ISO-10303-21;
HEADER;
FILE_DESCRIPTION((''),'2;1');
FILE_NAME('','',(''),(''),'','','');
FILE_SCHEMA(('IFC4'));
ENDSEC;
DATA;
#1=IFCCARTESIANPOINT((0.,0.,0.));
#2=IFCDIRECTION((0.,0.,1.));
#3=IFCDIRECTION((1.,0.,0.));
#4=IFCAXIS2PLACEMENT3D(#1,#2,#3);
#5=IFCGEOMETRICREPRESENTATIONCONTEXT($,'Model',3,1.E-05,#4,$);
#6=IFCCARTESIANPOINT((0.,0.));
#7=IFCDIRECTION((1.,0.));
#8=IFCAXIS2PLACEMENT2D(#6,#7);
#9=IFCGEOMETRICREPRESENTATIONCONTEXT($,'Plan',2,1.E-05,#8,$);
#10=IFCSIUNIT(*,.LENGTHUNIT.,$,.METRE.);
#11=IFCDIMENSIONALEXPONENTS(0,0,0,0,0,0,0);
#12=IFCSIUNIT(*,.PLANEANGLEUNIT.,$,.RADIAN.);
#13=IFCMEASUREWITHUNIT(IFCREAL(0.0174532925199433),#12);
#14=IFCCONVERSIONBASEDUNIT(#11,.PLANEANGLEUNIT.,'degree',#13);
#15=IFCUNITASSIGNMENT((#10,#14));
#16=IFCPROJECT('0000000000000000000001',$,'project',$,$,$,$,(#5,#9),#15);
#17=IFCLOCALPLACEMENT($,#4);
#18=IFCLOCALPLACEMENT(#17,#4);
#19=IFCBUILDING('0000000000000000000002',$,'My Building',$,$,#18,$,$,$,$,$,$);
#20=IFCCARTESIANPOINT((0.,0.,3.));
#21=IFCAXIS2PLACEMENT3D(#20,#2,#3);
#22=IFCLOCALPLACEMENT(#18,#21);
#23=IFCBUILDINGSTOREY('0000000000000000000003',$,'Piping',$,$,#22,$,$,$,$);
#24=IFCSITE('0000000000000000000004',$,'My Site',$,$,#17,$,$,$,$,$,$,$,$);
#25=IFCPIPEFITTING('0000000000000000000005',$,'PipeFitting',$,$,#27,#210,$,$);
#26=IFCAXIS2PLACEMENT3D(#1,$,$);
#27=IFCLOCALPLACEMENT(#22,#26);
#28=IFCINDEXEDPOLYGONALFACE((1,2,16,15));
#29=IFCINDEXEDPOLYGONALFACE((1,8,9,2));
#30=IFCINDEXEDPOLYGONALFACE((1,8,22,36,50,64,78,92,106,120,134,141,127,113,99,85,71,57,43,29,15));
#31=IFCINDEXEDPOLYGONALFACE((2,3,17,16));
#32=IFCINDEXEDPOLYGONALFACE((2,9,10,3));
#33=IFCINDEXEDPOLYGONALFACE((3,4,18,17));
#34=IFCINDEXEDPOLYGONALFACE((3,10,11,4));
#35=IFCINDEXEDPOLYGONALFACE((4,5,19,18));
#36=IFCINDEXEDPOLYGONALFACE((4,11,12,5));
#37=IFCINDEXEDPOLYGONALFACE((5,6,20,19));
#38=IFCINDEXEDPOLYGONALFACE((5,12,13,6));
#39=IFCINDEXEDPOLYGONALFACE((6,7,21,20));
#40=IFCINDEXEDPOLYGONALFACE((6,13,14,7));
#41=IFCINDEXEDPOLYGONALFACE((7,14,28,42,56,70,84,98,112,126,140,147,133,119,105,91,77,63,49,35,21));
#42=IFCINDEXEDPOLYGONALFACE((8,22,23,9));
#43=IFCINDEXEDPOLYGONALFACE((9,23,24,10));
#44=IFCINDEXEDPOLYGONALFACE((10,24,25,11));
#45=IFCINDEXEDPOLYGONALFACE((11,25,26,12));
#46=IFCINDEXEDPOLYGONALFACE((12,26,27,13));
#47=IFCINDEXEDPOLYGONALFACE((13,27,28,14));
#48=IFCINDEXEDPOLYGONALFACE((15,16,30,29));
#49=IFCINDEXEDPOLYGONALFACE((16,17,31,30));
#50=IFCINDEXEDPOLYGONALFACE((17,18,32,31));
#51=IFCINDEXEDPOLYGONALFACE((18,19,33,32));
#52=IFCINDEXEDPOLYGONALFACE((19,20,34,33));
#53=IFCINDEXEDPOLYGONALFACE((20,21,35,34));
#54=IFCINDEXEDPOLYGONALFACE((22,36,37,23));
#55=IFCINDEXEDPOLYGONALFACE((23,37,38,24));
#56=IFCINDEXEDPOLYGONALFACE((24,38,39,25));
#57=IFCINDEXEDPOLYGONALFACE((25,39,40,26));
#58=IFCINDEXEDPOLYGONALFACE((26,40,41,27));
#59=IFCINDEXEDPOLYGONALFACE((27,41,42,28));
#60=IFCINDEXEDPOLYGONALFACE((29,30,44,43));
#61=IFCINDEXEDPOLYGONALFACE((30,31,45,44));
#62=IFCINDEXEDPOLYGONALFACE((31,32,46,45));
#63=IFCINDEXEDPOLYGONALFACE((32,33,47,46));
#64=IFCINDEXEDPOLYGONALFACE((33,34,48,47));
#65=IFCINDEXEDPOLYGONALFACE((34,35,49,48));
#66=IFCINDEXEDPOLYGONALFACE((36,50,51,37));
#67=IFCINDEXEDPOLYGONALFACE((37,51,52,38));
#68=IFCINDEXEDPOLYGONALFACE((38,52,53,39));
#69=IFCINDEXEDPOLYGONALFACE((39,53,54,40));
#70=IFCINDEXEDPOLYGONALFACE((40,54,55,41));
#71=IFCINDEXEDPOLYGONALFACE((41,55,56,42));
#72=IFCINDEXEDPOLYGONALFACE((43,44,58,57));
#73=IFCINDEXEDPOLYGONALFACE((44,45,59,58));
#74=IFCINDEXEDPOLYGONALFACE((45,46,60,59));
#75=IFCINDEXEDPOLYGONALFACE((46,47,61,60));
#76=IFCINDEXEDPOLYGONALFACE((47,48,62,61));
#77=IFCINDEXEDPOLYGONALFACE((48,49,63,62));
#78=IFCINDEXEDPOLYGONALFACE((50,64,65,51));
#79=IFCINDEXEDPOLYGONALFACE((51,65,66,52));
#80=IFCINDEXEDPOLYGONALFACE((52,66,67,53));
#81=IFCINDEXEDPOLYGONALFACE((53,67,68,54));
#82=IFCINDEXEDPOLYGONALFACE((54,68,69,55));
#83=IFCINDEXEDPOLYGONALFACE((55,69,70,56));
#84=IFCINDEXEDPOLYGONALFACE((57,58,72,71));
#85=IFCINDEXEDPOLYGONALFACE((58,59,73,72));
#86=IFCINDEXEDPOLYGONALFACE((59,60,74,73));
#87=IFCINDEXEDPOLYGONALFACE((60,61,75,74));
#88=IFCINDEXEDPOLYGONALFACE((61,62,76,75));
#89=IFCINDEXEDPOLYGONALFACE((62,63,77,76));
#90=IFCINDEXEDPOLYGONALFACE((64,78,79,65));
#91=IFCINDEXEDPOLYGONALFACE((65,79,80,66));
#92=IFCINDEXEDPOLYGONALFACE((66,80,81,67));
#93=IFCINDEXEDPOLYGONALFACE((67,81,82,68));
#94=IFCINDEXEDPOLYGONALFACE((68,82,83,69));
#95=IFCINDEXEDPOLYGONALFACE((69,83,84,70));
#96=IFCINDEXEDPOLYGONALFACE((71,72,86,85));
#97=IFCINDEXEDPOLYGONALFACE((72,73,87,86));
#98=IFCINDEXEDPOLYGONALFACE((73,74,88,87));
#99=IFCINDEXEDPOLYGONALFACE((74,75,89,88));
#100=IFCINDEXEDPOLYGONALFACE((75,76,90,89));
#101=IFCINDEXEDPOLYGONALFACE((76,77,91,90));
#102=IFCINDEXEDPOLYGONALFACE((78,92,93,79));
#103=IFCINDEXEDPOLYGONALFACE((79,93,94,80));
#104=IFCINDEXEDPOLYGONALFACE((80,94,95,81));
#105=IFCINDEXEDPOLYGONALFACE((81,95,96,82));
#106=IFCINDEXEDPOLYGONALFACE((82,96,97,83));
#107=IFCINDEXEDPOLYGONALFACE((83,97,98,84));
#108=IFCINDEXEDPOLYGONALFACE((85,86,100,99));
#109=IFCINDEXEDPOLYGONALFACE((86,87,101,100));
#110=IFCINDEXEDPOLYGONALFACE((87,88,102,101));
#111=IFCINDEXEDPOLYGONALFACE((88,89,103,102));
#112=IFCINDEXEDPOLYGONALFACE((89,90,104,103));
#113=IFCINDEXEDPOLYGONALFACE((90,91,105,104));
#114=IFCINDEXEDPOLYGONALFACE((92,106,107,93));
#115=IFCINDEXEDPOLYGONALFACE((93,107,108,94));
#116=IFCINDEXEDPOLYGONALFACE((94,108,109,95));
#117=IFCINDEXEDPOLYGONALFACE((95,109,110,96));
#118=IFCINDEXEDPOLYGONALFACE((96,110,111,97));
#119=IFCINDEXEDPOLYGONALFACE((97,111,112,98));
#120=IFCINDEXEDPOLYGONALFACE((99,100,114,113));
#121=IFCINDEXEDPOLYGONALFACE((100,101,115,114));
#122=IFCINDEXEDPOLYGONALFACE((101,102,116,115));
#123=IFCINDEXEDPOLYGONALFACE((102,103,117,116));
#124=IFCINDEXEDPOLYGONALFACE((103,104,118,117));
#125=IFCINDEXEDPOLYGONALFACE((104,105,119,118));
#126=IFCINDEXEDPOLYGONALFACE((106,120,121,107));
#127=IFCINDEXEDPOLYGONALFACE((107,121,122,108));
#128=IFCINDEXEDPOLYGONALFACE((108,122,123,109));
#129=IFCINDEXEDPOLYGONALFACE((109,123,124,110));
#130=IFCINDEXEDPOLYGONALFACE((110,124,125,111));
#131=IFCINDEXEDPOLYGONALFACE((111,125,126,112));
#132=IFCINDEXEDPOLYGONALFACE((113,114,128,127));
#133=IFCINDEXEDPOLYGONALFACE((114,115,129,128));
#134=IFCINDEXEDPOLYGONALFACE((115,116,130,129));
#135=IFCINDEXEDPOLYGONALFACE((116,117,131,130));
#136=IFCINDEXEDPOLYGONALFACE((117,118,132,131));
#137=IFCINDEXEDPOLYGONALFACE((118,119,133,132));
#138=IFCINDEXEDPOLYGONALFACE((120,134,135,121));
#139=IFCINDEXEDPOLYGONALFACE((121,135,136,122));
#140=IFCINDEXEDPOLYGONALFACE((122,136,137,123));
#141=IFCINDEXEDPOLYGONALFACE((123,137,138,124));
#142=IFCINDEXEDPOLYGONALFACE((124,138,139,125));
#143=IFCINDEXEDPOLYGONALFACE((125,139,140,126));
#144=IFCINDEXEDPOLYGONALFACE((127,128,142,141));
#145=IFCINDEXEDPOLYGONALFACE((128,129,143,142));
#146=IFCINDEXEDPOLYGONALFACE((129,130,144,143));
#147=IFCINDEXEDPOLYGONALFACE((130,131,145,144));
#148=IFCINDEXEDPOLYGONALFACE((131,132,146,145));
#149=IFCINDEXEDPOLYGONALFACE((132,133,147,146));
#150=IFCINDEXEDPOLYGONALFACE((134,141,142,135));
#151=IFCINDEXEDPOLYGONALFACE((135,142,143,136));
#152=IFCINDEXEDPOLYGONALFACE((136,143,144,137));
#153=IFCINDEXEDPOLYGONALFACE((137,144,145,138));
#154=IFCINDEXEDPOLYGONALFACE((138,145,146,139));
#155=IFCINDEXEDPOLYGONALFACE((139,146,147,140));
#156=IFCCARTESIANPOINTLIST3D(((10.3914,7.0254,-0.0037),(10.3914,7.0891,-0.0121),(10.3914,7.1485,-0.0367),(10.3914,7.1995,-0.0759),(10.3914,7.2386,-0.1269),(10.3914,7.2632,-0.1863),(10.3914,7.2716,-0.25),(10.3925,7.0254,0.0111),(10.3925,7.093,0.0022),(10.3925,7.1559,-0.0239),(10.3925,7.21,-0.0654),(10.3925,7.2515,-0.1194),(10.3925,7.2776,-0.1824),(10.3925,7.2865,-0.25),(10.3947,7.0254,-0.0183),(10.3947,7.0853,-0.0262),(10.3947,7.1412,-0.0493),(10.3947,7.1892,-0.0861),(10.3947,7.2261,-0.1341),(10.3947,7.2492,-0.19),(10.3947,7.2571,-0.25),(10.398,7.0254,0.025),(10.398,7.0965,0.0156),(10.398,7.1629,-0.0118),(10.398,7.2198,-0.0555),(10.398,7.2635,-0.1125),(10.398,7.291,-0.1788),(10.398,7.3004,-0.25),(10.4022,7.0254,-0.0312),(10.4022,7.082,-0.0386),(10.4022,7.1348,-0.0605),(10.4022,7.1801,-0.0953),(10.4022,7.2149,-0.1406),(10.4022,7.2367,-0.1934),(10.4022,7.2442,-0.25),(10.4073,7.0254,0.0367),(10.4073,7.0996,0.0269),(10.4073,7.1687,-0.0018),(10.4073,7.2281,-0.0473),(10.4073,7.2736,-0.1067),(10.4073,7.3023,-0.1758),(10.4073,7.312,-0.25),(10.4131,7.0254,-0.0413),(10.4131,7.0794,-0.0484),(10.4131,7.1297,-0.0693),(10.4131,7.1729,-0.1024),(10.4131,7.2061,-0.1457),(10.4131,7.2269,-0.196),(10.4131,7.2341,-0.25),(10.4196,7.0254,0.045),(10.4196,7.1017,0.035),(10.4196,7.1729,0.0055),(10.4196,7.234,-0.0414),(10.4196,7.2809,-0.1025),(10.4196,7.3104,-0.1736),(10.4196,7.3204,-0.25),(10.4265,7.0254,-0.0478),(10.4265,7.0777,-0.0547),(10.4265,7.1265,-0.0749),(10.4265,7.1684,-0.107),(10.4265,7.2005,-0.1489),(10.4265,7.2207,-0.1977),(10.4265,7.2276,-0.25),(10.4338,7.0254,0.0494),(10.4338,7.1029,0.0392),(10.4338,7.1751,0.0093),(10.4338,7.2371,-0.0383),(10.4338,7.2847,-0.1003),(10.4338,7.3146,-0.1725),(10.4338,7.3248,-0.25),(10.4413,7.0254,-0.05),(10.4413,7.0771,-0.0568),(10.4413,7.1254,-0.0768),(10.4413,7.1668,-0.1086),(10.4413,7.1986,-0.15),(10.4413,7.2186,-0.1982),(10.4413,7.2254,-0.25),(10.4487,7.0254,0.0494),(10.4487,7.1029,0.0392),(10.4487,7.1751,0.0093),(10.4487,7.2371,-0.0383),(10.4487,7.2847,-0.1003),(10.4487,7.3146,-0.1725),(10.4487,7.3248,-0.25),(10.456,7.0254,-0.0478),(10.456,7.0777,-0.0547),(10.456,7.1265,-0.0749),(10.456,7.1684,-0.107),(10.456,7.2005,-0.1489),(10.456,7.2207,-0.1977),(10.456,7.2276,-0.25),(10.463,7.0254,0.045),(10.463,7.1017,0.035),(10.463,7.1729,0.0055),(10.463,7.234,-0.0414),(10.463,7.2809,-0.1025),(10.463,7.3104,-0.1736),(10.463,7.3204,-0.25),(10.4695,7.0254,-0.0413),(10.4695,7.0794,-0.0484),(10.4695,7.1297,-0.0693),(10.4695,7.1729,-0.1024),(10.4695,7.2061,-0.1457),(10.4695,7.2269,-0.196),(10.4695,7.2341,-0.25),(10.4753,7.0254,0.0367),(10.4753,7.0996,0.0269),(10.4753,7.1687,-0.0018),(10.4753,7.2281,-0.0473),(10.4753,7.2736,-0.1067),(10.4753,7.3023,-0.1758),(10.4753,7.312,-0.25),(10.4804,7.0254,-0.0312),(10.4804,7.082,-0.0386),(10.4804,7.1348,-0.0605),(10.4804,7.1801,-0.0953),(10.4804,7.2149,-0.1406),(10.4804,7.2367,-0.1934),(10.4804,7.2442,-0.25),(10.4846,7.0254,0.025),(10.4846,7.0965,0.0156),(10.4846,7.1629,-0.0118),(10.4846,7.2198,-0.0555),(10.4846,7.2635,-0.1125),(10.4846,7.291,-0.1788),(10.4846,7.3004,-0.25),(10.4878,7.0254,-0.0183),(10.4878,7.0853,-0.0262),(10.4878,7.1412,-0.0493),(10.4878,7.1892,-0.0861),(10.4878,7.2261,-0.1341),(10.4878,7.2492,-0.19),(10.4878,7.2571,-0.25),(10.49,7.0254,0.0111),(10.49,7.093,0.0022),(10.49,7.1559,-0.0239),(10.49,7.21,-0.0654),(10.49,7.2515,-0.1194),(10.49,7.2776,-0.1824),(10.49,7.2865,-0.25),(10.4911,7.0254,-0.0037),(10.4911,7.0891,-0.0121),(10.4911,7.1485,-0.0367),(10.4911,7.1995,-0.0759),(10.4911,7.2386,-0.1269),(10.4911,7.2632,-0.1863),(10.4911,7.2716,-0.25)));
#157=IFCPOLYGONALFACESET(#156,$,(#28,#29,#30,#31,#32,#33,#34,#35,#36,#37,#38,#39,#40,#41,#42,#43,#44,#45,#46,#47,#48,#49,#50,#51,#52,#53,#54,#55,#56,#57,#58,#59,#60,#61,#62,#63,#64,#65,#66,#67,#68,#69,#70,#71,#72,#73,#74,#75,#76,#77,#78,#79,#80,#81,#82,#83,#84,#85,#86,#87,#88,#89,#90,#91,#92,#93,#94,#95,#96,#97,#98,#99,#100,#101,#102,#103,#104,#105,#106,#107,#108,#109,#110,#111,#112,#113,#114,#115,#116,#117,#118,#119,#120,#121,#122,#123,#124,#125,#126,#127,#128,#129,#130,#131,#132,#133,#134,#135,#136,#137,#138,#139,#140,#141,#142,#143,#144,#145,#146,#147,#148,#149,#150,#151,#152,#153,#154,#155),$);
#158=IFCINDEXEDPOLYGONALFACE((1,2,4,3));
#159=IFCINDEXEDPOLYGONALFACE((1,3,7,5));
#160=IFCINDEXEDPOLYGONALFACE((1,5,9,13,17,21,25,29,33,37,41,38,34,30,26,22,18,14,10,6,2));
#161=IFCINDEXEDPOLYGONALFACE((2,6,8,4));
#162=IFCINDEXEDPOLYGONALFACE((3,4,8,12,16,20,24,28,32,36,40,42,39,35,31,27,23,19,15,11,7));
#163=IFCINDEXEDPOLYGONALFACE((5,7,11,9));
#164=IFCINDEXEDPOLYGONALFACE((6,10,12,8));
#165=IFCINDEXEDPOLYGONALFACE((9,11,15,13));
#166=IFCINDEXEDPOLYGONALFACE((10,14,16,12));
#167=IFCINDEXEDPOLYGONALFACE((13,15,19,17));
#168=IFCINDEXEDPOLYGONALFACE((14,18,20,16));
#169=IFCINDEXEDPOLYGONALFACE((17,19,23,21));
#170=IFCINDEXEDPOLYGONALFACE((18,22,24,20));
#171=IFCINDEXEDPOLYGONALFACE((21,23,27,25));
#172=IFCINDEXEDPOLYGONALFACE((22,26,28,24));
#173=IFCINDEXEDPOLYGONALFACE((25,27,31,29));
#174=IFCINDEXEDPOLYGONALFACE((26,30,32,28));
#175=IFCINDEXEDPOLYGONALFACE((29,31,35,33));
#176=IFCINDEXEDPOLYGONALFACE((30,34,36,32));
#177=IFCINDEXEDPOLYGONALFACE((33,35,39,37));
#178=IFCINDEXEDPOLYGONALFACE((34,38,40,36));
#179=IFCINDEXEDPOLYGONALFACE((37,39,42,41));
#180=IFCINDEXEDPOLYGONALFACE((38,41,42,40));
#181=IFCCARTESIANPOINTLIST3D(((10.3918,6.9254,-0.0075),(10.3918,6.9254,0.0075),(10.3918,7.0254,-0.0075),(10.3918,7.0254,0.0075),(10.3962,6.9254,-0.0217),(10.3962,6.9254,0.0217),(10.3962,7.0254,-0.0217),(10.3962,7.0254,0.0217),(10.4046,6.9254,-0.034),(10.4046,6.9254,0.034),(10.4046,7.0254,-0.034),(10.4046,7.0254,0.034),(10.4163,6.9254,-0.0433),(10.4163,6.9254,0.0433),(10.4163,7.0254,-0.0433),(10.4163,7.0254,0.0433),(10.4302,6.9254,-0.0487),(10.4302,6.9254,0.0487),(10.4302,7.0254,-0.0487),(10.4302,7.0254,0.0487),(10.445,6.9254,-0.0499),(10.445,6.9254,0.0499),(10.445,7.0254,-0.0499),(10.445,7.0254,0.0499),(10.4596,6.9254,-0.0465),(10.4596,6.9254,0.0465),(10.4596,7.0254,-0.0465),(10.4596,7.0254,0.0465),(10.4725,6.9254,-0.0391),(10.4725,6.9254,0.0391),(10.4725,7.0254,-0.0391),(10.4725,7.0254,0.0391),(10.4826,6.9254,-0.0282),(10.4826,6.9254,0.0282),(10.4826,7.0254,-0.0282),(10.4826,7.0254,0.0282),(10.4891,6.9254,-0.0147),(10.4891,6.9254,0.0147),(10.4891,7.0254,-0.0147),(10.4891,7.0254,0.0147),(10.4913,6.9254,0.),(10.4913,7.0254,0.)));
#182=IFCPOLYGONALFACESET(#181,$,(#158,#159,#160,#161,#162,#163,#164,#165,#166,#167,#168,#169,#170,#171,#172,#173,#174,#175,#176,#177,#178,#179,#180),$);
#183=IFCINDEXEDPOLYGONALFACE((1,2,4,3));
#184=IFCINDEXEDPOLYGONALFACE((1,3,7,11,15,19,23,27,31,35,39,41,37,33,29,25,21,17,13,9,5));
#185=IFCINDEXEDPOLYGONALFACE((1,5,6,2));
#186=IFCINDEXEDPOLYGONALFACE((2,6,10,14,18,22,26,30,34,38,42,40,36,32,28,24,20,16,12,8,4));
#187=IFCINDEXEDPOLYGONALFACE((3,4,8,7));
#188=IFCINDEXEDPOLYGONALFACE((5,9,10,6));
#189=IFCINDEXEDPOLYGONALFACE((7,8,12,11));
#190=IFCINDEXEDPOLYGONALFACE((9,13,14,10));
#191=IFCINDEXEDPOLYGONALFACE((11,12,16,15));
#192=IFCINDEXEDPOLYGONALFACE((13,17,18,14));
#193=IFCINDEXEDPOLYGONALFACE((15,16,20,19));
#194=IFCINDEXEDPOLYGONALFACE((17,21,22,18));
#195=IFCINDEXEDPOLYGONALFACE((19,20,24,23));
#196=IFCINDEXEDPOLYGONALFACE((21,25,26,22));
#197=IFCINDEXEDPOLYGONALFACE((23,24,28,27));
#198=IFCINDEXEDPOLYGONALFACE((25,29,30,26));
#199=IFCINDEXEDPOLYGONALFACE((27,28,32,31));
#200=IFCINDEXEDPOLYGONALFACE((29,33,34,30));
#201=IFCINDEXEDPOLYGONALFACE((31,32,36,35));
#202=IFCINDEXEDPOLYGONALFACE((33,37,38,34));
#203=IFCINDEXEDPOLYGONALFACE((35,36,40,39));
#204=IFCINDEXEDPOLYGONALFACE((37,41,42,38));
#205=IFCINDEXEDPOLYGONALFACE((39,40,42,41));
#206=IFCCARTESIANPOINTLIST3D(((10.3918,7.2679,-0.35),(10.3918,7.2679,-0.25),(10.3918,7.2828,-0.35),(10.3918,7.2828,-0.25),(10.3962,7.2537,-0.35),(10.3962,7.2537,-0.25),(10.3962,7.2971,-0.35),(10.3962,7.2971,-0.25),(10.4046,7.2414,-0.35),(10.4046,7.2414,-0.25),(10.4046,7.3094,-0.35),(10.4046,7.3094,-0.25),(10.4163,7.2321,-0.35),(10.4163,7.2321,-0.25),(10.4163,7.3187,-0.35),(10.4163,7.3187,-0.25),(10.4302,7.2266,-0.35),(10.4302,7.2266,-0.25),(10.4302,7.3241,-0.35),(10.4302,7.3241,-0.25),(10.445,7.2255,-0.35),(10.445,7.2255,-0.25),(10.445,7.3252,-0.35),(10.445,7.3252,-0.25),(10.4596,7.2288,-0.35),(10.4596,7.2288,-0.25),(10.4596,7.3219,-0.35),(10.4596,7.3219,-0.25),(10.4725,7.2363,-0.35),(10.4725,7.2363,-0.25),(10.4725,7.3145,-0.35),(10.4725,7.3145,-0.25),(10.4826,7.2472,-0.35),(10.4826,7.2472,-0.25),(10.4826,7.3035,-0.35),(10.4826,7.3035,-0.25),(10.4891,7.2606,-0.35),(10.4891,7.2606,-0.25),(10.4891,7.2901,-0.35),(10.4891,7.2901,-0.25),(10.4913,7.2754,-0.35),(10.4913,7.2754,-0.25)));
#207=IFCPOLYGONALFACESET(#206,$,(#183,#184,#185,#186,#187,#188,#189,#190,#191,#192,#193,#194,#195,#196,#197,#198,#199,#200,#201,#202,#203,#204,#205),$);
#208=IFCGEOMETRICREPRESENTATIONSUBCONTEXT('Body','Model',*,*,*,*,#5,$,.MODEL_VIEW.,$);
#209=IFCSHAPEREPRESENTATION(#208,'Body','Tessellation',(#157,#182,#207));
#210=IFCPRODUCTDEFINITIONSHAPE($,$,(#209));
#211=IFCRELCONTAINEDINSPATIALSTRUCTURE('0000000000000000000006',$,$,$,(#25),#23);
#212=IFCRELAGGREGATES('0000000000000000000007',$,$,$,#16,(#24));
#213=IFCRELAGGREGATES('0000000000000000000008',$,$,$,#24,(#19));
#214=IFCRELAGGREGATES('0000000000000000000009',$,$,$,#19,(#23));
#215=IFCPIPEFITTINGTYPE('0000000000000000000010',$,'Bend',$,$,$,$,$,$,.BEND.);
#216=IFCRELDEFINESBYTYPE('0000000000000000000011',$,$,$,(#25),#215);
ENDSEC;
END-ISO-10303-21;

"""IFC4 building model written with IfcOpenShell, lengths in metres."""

from ifc_helpers import new_model, entity, si_unit, converted_unit, frame, origin_with_axes, origin_2d_with_axis, place, context, subcontext, project, spatial, circle, extrude, source, transform, mapped, type_object, type_shapes, element, save


model = new_model("IFC4")

# Units and contexts
model_context = context("Model", 3, precision=1e-05, world=origin_with_axes())
plan_context = context("Plan", 2, precision=1e-05, world=origin_2d_with_axis())
body_context = subcontext(model_context, "Body", "Model", "MODEL_VIEW")
ifc_project = project(units=[si_unit("LENGTHUNIT", "METRE"), converted_unit("PLANEANGLEUNIT", "degree", entity("IfcReal", 0.0174532925199433), si_unit("PLANEANGLEUNIT", "RADIAN"), dimensions=[0, 0, 0, 0, 0, 0, 0])], contexts=[model_context, plan_context])

# Site, building, storey
site_placement = place(None, origin_with_axes())
site = spatial("IfcSite", under=ifc_project, at=site_placement, Name="My Site")
building_placement = place(site_placement, origin_with_axes())
building = spatial("IfcBuilding", under=site, at=building_placement, Name="My Building")
storey_placement = place(building_placement, frame((0.0, 0.0, 3.0), z_axis=(0.0, 0.0, 1.0), x_axis=(1.0, 0.0, 0.0)))
storey = spatial("IfcBuildingStorey", under=building, at=storey_placement, Name="Piping")

# Pipe fitting
pipe_fitting_type = type_object("IfcPipeFittingType", Name="Bend", PredefinedType="BEND")
shared_shape = source(origin_with_axes(), body_context, "Body", "SolidModel", [
    entity("IfcSweptDiskSolid", entity("IfcIndexedPolyCurve", entity("IfcCartesianPointList3D", [[0.0, 0.0, -0.1], [0.0, -0.0732, -0.2768], [0.0, -0.25, -0.35]]), [entity("IfcArcIndex", [1, 2, 3])]), 0.05),
    extrude(circle(Radius=0.05), origin_with_axes(), (0.0, 0.0, -1.0), 0.1),
    extrude(circle(Radius=0.05), frame((0.0, -0.25, -0.35), z_axis=(0.0, -1.0, 0.0), x_axis=(1.0, 0.0, 0.0)), (0.0, 0.0, 1.0), 0.1),
])
type_shapes(pipe_fitting_type, [shared_shape])
for number, where, z_axis, x_axis, name in (
    (1, (10.4413, 6.9254, 0.0), (0.0, -1.0, 0.0), (1.0, 0.0, 0.0), "PipeFitting"),
):
    element("IfcPipeFitting", number, at=place(storey_placement, frame(where, z_axis=z_axis, x_axis=x_axis)), inside=storey, type_object=pipe_fitting_type, Name=name, context=body_context, shape_type="MappedRepresentation", body=[
        mapped(shared_shape, transform((0.0, 0.0, 0.0), x_axis=(1.0, 0.0, 0.0), y_axis=(0.0, 1.0, 0.0), z_axis=(0.0, 0.0, 1.0), scale=1.0)),
    ])

save(model, "model.ifc")
